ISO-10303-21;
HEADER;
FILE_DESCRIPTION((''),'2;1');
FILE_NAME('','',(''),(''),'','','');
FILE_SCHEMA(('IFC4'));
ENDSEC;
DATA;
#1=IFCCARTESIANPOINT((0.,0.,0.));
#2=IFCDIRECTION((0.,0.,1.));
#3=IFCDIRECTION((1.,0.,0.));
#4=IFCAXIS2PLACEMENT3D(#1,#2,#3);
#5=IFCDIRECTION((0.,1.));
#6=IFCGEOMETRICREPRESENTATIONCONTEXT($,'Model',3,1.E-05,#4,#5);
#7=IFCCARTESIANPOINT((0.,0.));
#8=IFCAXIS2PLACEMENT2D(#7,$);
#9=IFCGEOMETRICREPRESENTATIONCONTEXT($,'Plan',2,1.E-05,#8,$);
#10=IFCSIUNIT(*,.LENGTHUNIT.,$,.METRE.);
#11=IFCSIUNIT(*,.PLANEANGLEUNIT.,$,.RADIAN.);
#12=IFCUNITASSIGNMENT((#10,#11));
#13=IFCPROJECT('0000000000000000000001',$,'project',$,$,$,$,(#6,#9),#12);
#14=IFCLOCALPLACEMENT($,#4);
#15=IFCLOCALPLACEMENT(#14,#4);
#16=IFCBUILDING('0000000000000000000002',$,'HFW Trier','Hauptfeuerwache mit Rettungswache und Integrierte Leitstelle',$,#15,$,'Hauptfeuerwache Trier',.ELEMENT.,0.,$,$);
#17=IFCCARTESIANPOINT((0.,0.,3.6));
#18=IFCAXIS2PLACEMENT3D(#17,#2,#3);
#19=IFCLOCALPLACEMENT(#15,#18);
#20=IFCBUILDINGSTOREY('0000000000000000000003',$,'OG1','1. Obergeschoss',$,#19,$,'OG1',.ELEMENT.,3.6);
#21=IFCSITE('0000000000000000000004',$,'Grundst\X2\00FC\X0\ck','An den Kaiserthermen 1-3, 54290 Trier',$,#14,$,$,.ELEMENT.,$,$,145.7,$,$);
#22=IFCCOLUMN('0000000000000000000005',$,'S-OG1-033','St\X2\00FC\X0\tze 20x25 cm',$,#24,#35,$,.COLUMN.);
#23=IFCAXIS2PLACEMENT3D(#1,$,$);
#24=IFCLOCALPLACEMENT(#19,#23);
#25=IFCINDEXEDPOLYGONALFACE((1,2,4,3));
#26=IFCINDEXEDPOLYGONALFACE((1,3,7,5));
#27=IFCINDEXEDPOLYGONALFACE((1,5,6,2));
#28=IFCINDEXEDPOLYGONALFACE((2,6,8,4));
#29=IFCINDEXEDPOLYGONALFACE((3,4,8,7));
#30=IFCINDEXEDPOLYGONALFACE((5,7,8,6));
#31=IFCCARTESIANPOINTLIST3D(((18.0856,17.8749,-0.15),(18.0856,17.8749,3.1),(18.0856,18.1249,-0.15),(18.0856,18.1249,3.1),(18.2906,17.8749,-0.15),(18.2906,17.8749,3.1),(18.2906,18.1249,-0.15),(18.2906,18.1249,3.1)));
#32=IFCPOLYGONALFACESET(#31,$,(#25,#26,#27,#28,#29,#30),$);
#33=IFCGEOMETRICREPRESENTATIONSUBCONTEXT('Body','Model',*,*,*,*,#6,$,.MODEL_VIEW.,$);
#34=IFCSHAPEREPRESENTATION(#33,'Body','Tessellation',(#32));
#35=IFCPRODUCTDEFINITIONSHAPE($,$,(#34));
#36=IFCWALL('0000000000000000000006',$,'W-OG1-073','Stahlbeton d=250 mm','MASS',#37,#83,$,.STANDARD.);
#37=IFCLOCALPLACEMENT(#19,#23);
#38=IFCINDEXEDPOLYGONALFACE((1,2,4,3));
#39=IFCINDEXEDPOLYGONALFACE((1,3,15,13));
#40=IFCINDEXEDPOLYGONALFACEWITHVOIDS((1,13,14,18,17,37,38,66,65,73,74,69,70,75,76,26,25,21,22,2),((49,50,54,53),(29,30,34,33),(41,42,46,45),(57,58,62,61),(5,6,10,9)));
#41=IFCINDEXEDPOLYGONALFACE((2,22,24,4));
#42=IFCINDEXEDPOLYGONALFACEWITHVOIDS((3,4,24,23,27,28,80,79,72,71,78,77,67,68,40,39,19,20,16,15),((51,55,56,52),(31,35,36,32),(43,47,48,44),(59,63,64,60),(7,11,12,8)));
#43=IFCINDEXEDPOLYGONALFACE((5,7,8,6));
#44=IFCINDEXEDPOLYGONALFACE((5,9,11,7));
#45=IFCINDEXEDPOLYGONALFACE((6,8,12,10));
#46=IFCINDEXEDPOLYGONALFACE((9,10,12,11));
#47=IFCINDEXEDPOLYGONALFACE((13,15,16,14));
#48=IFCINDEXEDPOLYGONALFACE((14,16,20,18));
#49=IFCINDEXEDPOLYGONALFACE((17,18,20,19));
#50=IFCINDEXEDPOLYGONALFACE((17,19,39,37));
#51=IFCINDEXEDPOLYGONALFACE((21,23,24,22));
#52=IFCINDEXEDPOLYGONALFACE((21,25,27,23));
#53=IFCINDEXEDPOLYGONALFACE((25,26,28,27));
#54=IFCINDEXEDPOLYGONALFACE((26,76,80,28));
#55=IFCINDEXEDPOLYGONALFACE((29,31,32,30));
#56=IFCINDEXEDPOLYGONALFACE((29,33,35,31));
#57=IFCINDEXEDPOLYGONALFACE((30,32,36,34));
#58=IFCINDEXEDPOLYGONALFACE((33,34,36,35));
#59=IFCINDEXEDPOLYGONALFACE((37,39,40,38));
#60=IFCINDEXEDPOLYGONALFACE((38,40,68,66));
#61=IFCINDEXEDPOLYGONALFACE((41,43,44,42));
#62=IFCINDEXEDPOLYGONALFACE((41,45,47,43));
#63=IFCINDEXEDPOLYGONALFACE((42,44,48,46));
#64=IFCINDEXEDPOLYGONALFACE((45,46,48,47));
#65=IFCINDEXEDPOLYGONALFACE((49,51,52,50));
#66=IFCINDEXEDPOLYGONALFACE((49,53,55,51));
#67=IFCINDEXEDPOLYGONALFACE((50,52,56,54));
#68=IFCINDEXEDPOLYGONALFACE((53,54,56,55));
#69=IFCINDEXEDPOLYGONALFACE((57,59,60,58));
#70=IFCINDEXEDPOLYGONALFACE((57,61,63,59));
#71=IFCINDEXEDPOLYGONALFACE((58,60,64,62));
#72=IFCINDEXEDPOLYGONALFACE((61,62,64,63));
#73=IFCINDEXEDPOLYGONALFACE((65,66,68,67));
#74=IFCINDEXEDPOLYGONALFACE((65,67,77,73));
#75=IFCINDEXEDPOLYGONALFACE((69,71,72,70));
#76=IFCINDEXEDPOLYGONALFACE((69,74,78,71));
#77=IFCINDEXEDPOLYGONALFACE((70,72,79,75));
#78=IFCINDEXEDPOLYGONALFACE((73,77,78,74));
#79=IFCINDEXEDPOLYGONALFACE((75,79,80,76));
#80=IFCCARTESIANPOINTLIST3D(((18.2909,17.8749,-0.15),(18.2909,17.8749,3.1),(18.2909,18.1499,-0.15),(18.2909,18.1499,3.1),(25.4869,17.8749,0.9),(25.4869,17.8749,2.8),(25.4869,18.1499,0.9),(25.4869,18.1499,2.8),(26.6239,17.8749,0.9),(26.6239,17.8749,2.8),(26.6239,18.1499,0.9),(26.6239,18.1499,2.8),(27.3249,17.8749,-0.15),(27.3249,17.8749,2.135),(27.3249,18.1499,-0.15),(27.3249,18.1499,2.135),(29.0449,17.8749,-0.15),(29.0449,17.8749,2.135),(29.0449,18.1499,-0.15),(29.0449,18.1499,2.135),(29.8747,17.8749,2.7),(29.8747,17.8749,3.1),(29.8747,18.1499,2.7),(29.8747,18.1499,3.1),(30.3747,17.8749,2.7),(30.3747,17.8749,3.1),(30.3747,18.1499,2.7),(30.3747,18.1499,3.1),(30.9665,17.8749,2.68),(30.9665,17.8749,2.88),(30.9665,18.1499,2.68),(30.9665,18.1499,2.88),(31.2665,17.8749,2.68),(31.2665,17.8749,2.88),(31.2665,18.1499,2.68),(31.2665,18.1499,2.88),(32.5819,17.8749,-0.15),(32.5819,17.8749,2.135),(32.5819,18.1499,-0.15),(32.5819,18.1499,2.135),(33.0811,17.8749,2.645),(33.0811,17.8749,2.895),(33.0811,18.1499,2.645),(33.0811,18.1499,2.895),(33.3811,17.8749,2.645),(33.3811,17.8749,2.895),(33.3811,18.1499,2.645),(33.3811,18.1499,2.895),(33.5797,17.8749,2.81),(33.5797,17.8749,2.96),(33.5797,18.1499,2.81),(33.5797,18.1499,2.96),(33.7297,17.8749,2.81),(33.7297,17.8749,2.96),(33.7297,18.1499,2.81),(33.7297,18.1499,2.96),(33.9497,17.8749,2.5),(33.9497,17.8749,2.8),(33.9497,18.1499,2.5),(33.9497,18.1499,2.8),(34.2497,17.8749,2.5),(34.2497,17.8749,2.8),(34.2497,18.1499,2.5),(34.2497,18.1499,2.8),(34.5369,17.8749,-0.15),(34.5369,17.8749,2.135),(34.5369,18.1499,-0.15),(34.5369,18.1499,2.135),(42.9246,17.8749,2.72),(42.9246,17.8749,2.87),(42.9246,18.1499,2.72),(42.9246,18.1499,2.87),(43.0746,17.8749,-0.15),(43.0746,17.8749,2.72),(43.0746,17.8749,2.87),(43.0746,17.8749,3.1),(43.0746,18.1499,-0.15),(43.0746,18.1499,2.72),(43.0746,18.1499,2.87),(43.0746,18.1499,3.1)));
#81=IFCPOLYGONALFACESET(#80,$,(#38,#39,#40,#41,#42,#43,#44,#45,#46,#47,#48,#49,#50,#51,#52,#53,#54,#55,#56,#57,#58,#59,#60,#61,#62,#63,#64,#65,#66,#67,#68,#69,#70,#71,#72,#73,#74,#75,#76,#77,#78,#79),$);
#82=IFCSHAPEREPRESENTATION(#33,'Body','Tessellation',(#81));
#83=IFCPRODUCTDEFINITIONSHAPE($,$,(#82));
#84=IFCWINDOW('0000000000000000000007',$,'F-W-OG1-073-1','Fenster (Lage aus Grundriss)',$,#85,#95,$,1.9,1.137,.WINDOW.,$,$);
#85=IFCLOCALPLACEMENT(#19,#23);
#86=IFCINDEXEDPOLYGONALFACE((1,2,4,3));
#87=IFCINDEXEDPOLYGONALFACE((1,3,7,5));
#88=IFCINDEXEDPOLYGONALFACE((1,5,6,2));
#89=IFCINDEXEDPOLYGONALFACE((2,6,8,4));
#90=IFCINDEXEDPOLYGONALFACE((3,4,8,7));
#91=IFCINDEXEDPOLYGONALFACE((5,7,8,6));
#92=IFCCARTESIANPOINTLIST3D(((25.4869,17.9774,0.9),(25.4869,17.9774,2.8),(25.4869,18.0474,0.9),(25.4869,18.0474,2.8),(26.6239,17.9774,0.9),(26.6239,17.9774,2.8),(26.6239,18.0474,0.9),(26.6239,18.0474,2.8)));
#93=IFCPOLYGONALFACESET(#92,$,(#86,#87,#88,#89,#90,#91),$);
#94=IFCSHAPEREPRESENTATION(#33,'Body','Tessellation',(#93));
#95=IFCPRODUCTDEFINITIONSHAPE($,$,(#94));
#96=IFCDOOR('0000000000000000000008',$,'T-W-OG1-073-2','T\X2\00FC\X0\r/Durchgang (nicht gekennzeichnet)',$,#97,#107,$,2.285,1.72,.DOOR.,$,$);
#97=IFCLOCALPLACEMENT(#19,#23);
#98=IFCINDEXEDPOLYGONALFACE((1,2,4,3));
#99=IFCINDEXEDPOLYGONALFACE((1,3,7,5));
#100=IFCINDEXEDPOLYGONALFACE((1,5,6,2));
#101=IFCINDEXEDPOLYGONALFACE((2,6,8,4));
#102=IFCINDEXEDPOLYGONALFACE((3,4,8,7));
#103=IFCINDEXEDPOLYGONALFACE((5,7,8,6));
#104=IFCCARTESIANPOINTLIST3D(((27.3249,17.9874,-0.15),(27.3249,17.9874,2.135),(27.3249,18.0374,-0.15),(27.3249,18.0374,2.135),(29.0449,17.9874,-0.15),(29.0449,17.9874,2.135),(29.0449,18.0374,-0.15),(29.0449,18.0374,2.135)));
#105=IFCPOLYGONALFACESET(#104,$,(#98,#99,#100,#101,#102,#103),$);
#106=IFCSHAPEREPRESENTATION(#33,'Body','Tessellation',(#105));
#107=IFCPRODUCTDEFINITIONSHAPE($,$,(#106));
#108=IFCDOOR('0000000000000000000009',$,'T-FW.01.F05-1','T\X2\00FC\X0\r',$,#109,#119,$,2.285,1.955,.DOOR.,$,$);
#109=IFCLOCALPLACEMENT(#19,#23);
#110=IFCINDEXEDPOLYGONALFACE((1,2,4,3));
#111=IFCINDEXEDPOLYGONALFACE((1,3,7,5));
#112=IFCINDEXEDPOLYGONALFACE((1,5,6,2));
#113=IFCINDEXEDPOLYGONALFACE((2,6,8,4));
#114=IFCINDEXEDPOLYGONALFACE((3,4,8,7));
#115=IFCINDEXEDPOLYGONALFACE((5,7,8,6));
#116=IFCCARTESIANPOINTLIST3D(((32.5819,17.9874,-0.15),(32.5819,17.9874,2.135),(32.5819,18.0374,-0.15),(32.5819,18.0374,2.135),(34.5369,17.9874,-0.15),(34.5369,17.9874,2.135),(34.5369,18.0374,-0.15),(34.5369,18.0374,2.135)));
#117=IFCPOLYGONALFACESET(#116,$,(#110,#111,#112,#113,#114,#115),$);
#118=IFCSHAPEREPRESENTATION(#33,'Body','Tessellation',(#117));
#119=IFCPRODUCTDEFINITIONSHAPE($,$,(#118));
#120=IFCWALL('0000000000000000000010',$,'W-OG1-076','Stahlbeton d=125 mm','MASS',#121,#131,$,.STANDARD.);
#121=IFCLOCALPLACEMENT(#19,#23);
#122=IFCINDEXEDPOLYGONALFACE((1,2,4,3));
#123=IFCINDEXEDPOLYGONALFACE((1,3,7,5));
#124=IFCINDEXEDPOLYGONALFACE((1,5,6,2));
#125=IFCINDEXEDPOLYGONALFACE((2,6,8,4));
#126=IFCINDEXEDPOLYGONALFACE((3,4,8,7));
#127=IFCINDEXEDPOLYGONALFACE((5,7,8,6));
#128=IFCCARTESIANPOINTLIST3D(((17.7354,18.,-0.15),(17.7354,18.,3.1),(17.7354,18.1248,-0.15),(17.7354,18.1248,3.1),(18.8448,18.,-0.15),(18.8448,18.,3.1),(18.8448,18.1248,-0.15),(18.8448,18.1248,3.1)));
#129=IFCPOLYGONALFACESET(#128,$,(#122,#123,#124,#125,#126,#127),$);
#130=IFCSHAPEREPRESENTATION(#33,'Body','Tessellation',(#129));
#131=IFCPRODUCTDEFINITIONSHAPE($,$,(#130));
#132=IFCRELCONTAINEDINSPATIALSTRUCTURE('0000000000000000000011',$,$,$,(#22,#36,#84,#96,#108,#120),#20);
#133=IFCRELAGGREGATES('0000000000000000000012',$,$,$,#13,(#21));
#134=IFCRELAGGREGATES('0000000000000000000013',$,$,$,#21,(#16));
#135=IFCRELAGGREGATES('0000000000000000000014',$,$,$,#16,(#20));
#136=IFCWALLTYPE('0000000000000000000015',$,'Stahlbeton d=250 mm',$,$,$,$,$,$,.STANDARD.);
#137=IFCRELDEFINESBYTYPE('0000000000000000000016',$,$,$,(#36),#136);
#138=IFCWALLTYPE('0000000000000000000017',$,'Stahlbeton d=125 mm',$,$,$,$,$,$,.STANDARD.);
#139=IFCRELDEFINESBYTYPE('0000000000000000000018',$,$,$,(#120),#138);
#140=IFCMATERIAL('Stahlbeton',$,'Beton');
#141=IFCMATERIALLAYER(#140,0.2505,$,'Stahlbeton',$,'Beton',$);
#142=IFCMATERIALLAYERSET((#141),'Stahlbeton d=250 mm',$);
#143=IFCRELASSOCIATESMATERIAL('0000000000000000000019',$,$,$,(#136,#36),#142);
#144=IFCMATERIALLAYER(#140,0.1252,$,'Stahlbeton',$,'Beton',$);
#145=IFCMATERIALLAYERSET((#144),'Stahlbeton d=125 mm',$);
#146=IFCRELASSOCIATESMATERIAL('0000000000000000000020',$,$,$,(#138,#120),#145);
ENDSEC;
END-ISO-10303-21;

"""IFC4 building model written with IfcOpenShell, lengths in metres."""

from ifc_helpers import new_model, si_unit, direction, frame, frame_2d, origin_with_axes, origin_2d, place, context, subcontext, project, spatial, rectangle, extrude, material, layer, layer_set, layer_usage, type_object, element, fill, save


model = new_model("IFC4")

# Units and contexts
model_context = context("Model", 3, precision=1e-05, world=origin_with_axes(), true_north=direction((0.0, 1.0)))
plan_context = context("Plan", 2, precision=1e-05, world=origin_2d())
body_context = subcontext(model_context, "Body", "Model", "MODEL_VIEW")
ifc_project = project(units=[si_unit("LENGTHUNIT", "METRE"), si_unit("PLANEANGLEUNIT", "RADIAN")], contexts=[model_context, plan_context])

# Site, building, storey
site_placement = place(None, origin_with_axes())
site = spatial("IfcSite", under=ifc_project, at=site_placement, Name="Grundstück", Description="An den Kaiserthermen 1-3, 54290 Trier", CompositionType="ELEMENT", RefElevation=145.7)
building_placement = place(site_placement, origin_with_axes())
building = spatial("IfcBuilding", under=site, at=building_placement, Name="HFW Trier", Description="Hauptfeuerwache mit Rettungswache und Integrierte Leitstelle", LongName="Hauptfeuerwache Trier", CompositionType="ELEMENT", ElevationOfRefHeight=0.0)
storey_placement = place(building_placement, frame((0.0, 0.0, 3.6), z_axis=(0.0, 0.0, 1.0), x_axis=(1.0, 0.0, 0.0)))
storey = spatial("IfcBuildingStorey", under=building, at=storey_placement, Name="OG1", Description="1. Obergeschoss", LongName="OG1", CompositionType="ELEMENT", Elevation=3.6)

# Column
column_placement = place(storey_placement, frame((18.0856, 17.9999, -0.15), z_axis=(0.0, 0.0, 1.0), x_axis=(1.0, 0.0, 0.0)))
element("IfcColumn", 1, at=column_placement, inside=storey, Name="S-OG1-033", Description="Stütze 20x25 cm", PredefinedType="COLUMN", context=body_context, shape_type="SweptSolid", body=[
    extrude(rectangle(XDim=0.205, YDim=0.25, at=frame_2d((0.1025, 0.0))), origin_with_axes(), (0.0, 0.0, 1.0), 3.25),
])

# Wall, openings, window, doors
ifc_material = material(Name="Stahlbeton", Category="Beton")
ifc_layer_1 = layer(ifc_material, 0.2505, Name="Stahlbeton", Category="Beton")
ifc_layer_set_1 = layer_set([ifc_layer_1], Name="Stahlbeton d=250 mm")
ifc_layer_usage_1 = layer_usage(ifc_layer_set_1, "AXIS2", "POSITIVE", -0.1375)
wall_type_1 = type_object("IfcWallType", Name="Stahlbeton d=250 mm", PredefinedType="STANDARD", material=ifc_layer_set_1)
wall_1_placement = place(storey_placement, frame((18.2909, 18.0124, -0.15), z_axis=(0.0, 0.0, 1.0), x_axis=(1.0, 0.0, 0.0)))
wall_1 = element("IfcWall", 2, at=wall_1_placement, inside=storey, type_object=wall_type_1, material=ifc_layer_usage_1, Name="W-OG1-073", Description="Stahlbeton d=250 mm", ObjectType="MASS", PredefinedType="STANDARD", context=body_context, shape_type="SweptSolid", body=[
    extrude(rectangle(XDim=24.7837, YDim=0.275, at=frame_2d((12.3918, 0.0))), origin_with_axes(), (0.0, 0.0, 1.0), 3.25),
])
opening_1_placement = place(wall_1_placement, frame((7.196, 0.0, 0.0), z_axis=(0.0, 0.0, 1.0), x_axis=(1.0, 0.0, 0.0)))
opening_1 = element("IfcOpeningElement", 3, at=opening_1_placement, cuts=wall_1, PredefinedType="OPENING", context=body_context, shape_type="SweptSolid", body=[
    extrude(rectangle(XDim=1.137, YDim=0.375, at=frame_2d((0.5685, 0.0))), frame((0.0, 0.0, 1.05), z_axis=(0.0, 0.0, 1.0), x_axis=(1.0, 0.0, 0.0)), (0.0, 0.0, 1.0), 1.9),
])
opening_2_placement = place(wall_1_placement, frame((9.034, 0.0, 0.0), z_axis=(0.0, 0.0, 1.0), x_axis=(1.0, 0.0, 0.0)))
opening_2 = element("IfcOpeningElement", 4, at=opening_2_placement, cuts=wall_1, PredefinedType="OPENING", context=body_context, shape_type="SweptSolid", body=[
    extrude(rectangle(XDim=1.72, YDim=0.375, at=frame_2d((0.86, 0.0))), origin_with_axes(), (0.0, 0.0, 1.0), 2.285),
])
opening_3_placement = place(wall_1_placement, frame((14.291, 0.0, 0.0), z_axis=(0.0, 0.0, 1.0), x_axis=(1.0, 0.0, 0.0)))
opening_3 = element("IfcOpeningElement", 5, at=opening_3_placement, cuts=wall_1, PredefinedType="OPENING", context=body_context, shape_type="SweptSolid", body=[
    extrude(rectangle(XDim=1.955, YDim=0.375, at=frame_2d((0.9775, 0.0))), origin_with_axes(), (0.0, 0.0, 1.0), 2.285),
])
opening_4_placement = place(wall_1_placement, origin_with_axes())
element("IfcOpeningElement", 6, at=opening_4_placement, cuts=wall_1, ObjectType="Wanddurchbruch", PredefinedType="OPENING", context=body_context, shape_type="SweptSolid", body=[
    extrude(rectangle(XDim=0.15, YDim=0.375, at=frame_2d((15.3638, 0.0))), frame((0.0, 0.0, 2.96), z_axis=(0.0, 0.0, 1.0), x_axis=(1.0, 0.0, 0.0)), (0.0, 0.0, 1.0), 0.15),
])
opening_5_placement = place(wall_1_placement, origin_with_axes())
element("IfcOpeningElement", 7, at=opening_5_placement, cuts=wall_1, ObjectType="Wanddurchbruch", PredefinedType="OPENING", context=body_context, shape_type="SweptSolid", body=[
    extrude(rectangle(XDim=0.5, YDim=0.375, at=frame_2d((11.8338, 0.0))), frame((0.0, 0.0, 2.85), z_axis=(0.0, 0.0, 1.0), x_axis=(1.0, 0.0, 0.0)), (0.0, 0.0, 1.0), 0.4),
])
opening_6_placement = place(wall_1_placement, origin_with_axes())
element("IfcOpeningElement", 8, at=opening_6_placement, cuts=wall_1, ObjectType="Wanddurchbruch", PredefinedType="OPENING", context=body_context, shape_type="SweptSolid", body=[
    extrude(rectangle(XDim=0.3, YDim=0.375, at=frame_2d((14.9402, 0.0))), frame((0.0, 0.0, 2.795), z_axis=(0.0, 0.0, 1.0), x_axis=(1.0, 0.0, 0.0)), (0.0, 0.0, 1.0), 0.25),
])
opening_7_placement = place(wall_1_placement, origin_with_axes())
element("IfcOpeningElement", 9, at=opening_7_placement, cuts=wall_1, ObjectType="Wanddurchbruch", PredefinedType="OPENING", context=body_context, shape_type="SweptSolid", body=[
    extrude(rectangle(XDim=0.3, YDim=0.375, at=frame_2d((12.8256, 0.0))), frame((0.0, 0.0, 2.83), z_axis=(0.0, 0.0, 1.0), x_axis=(1.0, 0.0, 0.0)), (0.0, 0.0, 1.0), 0.2),
])
opening_8_placement = place(wall_1_placement, origin_with_axes())
element("IfcOpeningElement", 10, at=opening_8_placement, cuts=wall_1, ObjectType="Wanddurchbruch", PredefinedType="OPENING", context=body_context, shape_type="SweptSolid", body=[
    extrude(rectangle(XDim=0.15, YDim=0.375, at=frame_2d((24.7087, 0.0))), frame((0.0, 0.0, 2.87), z_axis=(0.0, 0.0, 1.0), x_axis=(1.0, 0.0, 0.0)), (0.0, 0.0, 1.0), 0.15),
])
opening_9_placement = place(wall_1_placement, origin_with_axes())
element("IfcOpeningElement", 11, at=opening_9_placement, cuts=wall_1, ObjectType="Wanddurchbruch", PredefinedType="OPENING", context=body_context, shape_type="SweptSolid", body=[
    extrude(rectangle(XDim=0.3, YDim=0.375, at=frame_2d((15.8088, 0.0))), frame((0.0, 0.0, 2.65), z_axis=(0.0, 0.0, 1.0), x_axis=(1.0, 0.0, 0.0)), (0.0, 0.0, 1.0), 0.3),
])
window_placement = place(wall_1_placement, frame((7.196, 0.0, 0.0), z_axis=(0.0, 0.0, 1.0), x_axis=(1.0, 0.0, 0.0)))
window = element("IfcWindow", 12, at=window_placement, inside=storey, Name="F-W-OG1-073-1", Description="Fenster (Lage aus Grundriss)", OverallHeight=1.9, OverallWidth=1.137, PredefinedType="WINDOW", context=body_context, shape_type="SweptSolid", body=[
    extrude(rectangle(XDim=1.137, YDim=0.07, at=frame_2d((0.5685, 0.0))), frame((0.0, 0.0, 1.05), z_axis=(0.0, 0.0, 1.0), x_axis=(1.0, 0.0, 0.0)), (0.0, 0.0, 1.0), 1.9),
])
fill(opening_1, window)
door_1_placement = place(wall_1_placement, frame((9.034, 0.0, 0.0), z_axis=(0.0, 0.0, 1.0), x_axis=(1.0, 0.0, 0.0)))
door_1 = element("IfcDoor", 13, at=door_1_placement, inside=storey, Name="T-W-OG1-073-2", Description="Tür/Durchgang (nicht gekennzeichnet)", OverallHeight=2.285, OverallWidth=1.72, PredefinedType="DOOR", context=body_context, shape_type="SweptSolid", body=[
    extrude(rectangle(XDim=1.72, YDim=0.05, at=frame_2d((0.86, 0.0))), origin_with_axes(), (0.0, 0.0, 1.0), 2.285),
])
fill(opening_2, door_1)
door_2_placement = place(wall_1_placement, frame((14.291, 0.0, 0.0), z_axis=(0.0, 0.0, 1.0), x_axis=(1.0, 0.0, 0.0)))
door_2 = element("IfcDoor", 14, at=door_2_placement, inside=storey, Name="T-FW.01.F05-1", Description="Tür", OverallHeight=2.285, OverallWidth=1.955, PredefinedType="DOOR", context=body_context, shape_type="SweptSolid", body=[
    extrude(rectangle(XDim=1.955, YDim=0.05, at=frame_2d((0.9775, 0.0))), origin_with_axes(), (0.0, 0.0, 1.0), 2.285),
])
fill(opening_3, door_2)

# Wall
ifc_layer_2 = layer(ifc_material, 0.1252, Name="Stahlbeton", Category="Beton")
ifc_layer_set_2 = layer_set([ifc_layer_2], Name="Stahlbeton d=125 mm")
ifc_layer_usage_2 = layer_usage(ifc_layer_set_2, "AXIS2", "POSITIVE", -0.0624)
wall_type_2 = type_object("IfcWallType", Name="Stahlbeton d=125 mm", PredefinedType="STANDARD", material=ifc_layer_set_2)
wall_2_placement = place(storey_placement, frame((17.7354, 18.0624, -0.15), z_axis=(0.0, 0.0, 1.0), x_axis=(1.0, 0.0, 0.0)))
element("IfcWall", 15, at=wall_2_placement, inside=storey, type_object=wall_type_2, material=ifc_layer_usage_2, Name="W-OG1-076", Description="Stahlbeton d=125 mm", ObjectType="MASS", PredefinedType="STANDARD", context=body_context, shape_type="SweptSolid", body=[
    extrude(rectangle(XDim=1.1094, YDim=0.1249, at=frame_2d((0.5547, 0.0))), origin_with_axes(), (0.0, 0.0, 1.0), 3.25),
])

save(model, "model.ifc")
